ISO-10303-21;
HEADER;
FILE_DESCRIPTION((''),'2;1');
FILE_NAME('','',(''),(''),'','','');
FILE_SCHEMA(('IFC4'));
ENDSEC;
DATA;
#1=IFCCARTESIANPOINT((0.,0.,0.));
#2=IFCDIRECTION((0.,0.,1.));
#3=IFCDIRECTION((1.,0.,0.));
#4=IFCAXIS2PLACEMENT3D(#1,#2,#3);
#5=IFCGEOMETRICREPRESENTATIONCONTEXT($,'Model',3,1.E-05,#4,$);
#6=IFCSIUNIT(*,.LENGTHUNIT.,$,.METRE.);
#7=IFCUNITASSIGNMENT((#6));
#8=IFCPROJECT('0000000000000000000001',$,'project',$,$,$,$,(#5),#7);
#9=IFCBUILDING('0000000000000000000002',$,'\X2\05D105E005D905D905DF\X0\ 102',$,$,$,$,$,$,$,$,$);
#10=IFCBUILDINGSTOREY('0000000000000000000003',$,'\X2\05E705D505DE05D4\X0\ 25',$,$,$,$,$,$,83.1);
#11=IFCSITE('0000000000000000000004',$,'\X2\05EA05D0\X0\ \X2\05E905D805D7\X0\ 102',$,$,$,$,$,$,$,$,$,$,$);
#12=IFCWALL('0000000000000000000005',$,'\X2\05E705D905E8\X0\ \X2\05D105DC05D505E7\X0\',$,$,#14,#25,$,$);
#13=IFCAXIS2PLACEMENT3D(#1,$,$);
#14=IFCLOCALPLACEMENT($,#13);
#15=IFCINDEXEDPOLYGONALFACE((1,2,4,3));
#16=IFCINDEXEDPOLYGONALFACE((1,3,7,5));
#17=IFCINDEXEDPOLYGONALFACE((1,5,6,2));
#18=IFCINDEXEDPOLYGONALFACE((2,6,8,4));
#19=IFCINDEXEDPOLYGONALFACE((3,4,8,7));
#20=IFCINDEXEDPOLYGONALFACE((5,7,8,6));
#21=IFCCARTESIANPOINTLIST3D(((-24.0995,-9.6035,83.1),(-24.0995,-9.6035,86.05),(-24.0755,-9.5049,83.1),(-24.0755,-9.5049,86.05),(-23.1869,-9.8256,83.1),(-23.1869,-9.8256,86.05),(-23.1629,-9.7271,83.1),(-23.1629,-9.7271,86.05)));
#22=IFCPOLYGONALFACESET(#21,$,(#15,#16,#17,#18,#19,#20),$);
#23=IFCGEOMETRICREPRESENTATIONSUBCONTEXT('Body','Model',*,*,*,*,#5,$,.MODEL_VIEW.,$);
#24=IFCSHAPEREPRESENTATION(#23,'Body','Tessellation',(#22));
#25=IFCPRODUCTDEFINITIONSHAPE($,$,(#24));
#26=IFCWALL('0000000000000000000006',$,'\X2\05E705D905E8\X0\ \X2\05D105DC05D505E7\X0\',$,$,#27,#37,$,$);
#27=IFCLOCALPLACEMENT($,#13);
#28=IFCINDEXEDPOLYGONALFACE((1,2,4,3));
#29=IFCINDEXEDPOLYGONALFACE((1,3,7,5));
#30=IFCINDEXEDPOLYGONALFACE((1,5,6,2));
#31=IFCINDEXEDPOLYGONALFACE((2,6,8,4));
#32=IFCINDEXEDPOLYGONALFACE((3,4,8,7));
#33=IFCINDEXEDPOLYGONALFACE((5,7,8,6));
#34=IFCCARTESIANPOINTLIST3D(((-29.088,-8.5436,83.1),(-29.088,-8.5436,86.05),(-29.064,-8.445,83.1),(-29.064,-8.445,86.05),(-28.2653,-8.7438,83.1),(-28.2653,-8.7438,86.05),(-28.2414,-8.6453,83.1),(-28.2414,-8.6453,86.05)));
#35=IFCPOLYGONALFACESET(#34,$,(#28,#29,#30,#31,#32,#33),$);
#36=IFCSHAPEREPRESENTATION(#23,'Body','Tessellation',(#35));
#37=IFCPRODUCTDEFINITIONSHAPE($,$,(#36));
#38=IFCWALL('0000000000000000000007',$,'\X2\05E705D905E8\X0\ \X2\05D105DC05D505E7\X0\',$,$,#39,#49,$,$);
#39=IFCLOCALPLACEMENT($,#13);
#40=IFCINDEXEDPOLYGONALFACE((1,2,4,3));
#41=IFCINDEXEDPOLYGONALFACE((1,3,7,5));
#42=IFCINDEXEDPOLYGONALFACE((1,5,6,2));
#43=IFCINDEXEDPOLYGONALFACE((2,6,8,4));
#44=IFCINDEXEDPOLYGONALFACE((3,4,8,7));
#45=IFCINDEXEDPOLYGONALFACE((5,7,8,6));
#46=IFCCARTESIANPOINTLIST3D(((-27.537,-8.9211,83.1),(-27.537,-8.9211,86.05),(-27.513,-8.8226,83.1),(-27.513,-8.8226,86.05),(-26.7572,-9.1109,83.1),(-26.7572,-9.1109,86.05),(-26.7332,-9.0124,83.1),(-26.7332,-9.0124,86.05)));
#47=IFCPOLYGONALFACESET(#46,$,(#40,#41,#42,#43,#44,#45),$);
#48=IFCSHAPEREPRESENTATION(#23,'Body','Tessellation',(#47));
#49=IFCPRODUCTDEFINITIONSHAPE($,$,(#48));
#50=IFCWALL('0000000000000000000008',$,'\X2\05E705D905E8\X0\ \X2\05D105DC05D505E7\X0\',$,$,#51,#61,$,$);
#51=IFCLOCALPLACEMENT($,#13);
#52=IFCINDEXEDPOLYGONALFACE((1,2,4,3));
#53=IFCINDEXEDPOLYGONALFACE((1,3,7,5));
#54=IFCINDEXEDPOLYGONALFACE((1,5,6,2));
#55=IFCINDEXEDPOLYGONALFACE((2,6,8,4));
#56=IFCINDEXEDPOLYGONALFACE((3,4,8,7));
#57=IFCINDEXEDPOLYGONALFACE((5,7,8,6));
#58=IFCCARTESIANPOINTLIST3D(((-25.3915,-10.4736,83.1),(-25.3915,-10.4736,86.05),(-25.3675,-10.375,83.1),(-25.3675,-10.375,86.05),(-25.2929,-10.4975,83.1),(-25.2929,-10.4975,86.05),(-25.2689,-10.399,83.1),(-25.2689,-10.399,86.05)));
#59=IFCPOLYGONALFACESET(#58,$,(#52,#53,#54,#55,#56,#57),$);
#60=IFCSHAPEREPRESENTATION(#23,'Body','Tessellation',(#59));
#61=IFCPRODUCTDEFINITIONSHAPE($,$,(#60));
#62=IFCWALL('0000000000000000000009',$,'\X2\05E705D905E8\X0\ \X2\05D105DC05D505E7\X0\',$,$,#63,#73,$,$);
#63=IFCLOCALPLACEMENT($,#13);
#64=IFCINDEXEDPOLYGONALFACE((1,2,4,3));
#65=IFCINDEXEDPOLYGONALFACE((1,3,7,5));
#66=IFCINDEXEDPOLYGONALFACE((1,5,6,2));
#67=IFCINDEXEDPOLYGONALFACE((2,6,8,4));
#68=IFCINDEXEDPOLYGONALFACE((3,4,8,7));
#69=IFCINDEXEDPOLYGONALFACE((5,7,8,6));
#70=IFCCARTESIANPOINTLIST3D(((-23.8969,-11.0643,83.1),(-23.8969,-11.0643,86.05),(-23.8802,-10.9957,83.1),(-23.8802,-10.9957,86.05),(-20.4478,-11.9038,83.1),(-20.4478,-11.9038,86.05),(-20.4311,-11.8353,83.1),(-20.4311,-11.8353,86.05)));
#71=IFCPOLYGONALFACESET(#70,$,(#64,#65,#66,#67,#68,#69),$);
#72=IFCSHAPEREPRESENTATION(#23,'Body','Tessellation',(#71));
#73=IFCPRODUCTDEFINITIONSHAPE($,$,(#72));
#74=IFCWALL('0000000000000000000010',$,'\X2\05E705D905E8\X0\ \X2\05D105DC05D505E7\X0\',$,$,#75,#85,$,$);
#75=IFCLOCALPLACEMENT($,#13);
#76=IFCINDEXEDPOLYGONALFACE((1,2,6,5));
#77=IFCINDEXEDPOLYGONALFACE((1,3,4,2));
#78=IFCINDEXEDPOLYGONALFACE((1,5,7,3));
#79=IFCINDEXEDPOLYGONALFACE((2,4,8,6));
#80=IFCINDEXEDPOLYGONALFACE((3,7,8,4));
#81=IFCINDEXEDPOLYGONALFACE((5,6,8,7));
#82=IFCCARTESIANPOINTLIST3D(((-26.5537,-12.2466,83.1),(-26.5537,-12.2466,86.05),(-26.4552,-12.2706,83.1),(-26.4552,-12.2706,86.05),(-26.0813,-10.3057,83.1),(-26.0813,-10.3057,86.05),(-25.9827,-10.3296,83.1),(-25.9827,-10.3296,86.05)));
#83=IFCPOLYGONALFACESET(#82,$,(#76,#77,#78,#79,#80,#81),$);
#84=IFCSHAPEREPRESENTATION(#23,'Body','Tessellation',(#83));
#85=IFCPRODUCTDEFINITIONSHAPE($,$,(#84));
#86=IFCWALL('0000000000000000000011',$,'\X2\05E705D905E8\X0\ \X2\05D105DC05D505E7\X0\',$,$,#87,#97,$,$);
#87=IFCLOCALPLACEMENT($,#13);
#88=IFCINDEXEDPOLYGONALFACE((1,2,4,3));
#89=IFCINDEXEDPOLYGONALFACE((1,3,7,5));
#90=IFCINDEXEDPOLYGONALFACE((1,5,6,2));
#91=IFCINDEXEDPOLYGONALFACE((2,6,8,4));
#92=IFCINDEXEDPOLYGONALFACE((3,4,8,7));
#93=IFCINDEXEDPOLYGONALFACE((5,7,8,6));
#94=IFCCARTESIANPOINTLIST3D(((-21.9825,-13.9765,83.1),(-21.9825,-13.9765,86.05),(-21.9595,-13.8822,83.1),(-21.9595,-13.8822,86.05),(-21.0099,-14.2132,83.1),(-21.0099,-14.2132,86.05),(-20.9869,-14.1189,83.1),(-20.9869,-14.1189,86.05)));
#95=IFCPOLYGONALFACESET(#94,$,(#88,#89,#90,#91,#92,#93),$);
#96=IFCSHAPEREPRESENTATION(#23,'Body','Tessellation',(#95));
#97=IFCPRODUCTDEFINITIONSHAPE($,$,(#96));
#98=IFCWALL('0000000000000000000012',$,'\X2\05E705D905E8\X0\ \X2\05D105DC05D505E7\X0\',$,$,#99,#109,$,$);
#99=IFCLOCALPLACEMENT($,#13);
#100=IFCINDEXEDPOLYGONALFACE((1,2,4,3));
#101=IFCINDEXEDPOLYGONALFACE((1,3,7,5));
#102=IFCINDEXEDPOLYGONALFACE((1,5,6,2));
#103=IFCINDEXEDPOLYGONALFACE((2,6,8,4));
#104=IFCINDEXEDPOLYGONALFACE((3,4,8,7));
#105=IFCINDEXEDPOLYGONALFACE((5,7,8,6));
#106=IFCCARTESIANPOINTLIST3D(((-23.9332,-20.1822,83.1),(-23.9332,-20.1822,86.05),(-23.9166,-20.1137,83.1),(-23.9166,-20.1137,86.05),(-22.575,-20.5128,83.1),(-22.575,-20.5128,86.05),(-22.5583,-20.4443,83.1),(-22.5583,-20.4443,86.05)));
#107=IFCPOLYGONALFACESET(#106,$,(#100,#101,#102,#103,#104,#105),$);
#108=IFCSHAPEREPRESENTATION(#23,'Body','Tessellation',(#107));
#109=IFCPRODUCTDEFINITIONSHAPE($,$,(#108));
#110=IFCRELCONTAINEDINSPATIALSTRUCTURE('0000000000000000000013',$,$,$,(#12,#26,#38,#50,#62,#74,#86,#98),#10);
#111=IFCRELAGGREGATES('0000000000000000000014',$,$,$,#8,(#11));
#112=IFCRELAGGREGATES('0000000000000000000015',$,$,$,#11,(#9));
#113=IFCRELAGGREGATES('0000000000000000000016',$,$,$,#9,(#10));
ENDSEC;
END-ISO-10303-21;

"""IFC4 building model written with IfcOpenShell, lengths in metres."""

from ifc_helpers import new_model, si_unit, frame, origin_with_axes, context, subcontext, project, spatial, polyline, outline, extrude, element, save


model = new_model("IFC4")

# Units and contexts
model_context = context("Model", 3, precision=1e-05, world=origin_with_axes())
body_context = subcontext(model_context, "Body", "Model", "MODEL_VIEW")
ifc_project = project(units=[si_unit("LENGTHUNIT", "METRE")], contexts=[model_context])

# Site, building, storey
site = spatial("IfcSite", under=ifc_project, Name="תא שטח 102")
building = spatial("IfcBuilding", under=site, Name="בניין 102")
storey = spatial("IfcBuildingStorey", under=building, Name="קומה 25", Elevation=83.1)

# Walls
element("IfcWall", 1, inside=storey, Name="קיר בלוק", context=body_context, shape_type="SweptSolid", body=[
    extrude(outline(polyline([(-24.0755, -9.5049), (-24.0995, -9.6035), (-23.1869, -9.8256), (-23.1629, -9.7271), (-24.0755, -9.5049)])), frame((0.0, 0.0, 83.1)), (0.0, 0.0, 1.0), 2.95),
])
element("IfcWall", 2, inside=storey, Name="קיר בלוק", context=body_context, shape_type="SweptSolid", body=[
    extrude(outline(polyline([(-29.088, -8.5436), (-28.2653, -8.7438), (-28.2414, -8.6453), (-29.064, -8.445), (-29.088, -8.5436)])), frame((0.0, 0.0, 83.1)), (0.0, 0.0, 1.0), 2.95),
])
element("IfcWall", 3, inside=storey, Name="קיר בלוק", context=body_context, shape_type="SweptSolid", body=[
    extrude(outline(polyline([(-27.513, -8.8226), (-27.537, -8.9211), (-26.7572, -9.1109), (-26.7332, -9.0124), (-27.513, -8.8226)])), frame((0.0, 0.0, 83.1)), (0.0, 0.0, 1.0), 2.95),
])
element("IfcWall", 4, inside=storey, Name="קיר בלוק", context=body_context, shape_type="SweptSolid", body=[
    extrude(outline(polyline([(-25.3915, -10.4736), (-25.2929, -10.4975), (-25.2689, -10.399), (-25.3675, -10.375), (-25.3915, -10.4736)])), frame((0.0, 0.0, 83.1)), (0.0, 0.0, 1.0), 2.95),
])
element("IfcWall", 5, inside=storey, Name="קיר בלוק", context=body_context, shape_type="SweptSolid", body=[
    extrude(outline(polyline([(-20.4478, -11.9038), (-20.4311, -11.8353), (-23.8802, -10.9957), (-23.8969, -11.0643), (-20.4478, -11.9038)])), frame((0.0, 0.0, 83.1)), (0.0, 0.0, 1.0), 2.95),
])
element("IfcWall", 6, inside=storey, Name="קיר בלוק", context=body_context, shape_type="SweptSolid", body=[
    extrude(outline(polyline([(-26.5537, -12.2466), (-26.4552, -12.2706), (-25.9827, -10.3296), (-26.0813, -10.3057), (-26.5537, -12.2466)])), frame((0.0, 0.0, 83.1)), (0.0, 0.0, 1.0), 2.95),
])
element("IfcWall", 7, inside=storey, Name="קיר בלוק", context=body_context, shape_type="SweptSolid", body=[
    extrude(outline(polyline([(-21.9595, -13.8822), (-21.9825, -13.9765), (-21.0099, -14.2132), (-20.9869, -14.1189), (-21.9595, -13.8822)])), frame((0.0, 0.0, 83.1)), (0.0, 0.0, 1.0), 2.95),
])
element("IfcWall", 8, inside=storey, Name="קיר בלוק", context=body_context, shape_type="SweptSolid", body=[
    extrude(outline(polyline([(-22.5583, -20.4443), (-23.9166, -20.1137), (-23.9332, -20.1822), (-22.575, -20.5128), (-22.5583, -20.4443)])), frame((0.0, 0.0, 83.1)), (0.0, 0.0, 1.0), 2.95),
])

save(model, "model.ifc")
